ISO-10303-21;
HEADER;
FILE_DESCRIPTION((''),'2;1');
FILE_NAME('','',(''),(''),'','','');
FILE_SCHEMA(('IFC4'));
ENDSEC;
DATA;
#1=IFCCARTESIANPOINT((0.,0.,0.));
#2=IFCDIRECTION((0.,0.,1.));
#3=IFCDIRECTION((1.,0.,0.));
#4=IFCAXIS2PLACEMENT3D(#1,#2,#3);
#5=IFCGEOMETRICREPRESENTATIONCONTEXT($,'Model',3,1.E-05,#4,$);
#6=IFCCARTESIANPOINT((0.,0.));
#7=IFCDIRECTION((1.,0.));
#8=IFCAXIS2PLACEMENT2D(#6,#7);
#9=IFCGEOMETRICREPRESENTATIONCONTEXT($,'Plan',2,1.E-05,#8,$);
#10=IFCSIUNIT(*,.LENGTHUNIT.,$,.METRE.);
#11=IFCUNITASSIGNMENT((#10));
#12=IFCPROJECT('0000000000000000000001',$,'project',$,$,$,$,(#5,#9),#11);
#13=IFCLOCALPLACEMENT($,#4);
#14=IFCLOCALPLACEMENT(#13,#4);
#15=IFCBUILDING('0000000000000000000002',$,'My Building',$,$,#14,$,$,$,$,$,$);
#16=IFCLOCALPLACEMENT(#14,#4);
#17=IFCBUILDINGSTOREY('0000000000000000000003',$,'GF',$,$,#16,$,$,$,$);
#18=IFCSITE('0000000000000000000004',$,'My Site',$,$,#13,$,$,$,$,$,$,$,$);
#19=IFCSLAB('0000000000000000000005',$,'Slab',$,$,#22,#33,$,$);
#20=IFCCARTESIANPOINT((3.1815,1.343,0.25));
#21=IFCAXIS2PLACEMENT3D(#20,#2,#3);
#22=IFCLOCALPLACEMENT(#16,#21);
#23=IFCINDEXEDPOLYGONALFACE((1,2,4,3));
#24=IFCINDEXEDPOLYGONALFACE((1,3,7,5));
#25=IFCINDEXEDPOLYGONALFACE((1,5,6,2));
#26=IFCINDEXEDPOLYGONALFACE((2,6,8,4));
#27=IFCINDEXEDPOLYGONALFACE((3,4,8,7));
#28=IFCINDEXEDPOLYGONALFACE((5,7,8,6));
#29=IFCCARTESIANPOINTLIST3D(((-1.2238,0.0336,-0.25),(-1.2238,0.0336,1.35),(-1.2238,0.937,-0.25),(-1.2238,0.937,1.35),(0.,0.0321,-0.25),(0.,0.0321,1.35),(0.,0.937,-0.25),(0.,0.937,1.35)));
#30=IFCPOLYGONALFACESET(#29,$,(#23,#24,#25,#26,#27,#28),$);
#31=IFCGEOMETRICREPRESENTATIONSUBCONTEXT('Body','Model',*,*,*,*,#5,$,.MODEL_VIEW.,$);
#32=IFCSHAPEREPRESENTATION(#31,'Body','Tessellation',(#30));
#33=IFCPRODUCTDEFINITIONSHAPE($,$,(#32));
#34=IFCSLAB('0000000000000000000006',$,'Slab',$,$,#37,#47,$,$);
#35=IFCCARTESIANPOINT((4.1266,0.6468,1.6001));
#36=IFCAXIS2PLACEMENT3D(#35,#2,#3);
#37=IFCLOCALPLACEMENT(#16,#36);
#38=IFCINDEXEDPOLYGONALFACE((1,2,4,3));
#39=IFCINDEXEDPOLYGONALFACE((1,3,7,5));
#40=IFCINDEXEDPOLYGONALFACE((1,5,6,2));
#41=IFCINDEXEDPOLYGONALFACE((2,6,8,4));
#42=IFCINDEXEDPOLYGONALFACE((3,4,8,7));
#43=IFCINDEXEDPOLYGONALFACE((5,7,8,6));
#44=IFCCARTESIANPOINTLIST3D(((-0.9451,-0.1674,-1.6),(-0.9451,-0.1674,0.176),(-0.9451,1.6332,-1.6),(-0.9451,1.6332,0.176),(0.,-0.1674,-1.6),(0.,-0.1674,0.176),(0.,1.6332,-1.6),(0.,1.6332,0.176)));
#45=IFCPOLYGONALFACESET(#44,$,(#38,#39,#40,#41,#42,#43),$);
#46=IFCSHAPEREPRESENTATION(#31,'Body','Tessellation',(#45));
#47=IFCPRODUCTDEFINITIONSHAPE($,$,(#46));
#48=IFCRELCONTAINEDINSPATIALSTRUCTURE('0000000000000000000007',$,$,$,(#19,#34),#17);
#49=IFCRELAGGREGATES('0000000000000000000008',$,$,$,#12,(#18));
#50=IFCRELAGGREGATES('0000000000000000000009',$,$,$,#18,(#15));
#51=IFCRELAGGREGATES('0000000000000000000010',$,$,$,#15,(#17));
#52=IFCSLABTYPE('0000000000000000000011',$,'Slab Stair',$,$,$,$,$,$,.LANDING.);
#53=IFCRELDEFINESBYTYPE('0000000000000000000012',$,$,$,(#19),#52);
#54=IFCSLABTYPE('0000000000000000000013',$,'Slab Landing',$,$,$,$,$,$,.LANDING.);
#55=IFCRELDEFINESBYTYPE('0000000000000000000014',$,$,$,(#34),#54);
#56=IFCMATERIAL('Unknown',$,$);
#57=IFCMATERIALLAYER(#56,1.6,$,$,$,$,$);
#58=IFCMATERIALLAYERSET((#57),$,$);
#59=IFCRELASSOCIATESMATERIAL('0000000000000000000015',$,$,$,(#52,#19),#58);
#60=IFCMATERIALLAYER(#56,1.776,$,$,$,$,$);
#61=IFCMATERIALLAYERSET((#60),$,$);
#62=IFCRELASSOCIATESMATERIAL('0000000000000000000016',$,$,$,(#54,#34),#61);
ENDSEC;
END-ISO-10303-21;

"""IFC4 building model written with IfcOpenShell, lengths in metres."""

from ifc_helpers import new_model, si_unit, frame, origin_with_axes, origin_2d_with_axis, place, context, subcontext, project, spatial, indexed_curve, outline, extrude, material, layer, layer_set, layer_usage, type_object, element, save


model = new_model("IFC4")

# Units and contexts
model_context = context("Model", 3, precision=1e-05, world=origin_with_axes())
plan_context = context("Plan", 2, precision=1e-05, world=origin_2d_with_axis())
body_context_1 = subcontext(model_context, "Body", "Model", "MODEL_VIEW")
ifc_project = project(units=[si_unit("LENGTHUNIT", "METRE")], contexts=[model_context, plan_context])

# Site, building, storey
site_placement = place(None, origin_with_axes())
site = spatial("IfcSite", under=ifc_project, at=site_placement, Name="My Site")
building_placement = place(site_placement, origin_with_axes())
building = spatial("IfcBuilding", under=site, at=building_placement, Name="My Building")
storey_placement = place(building_placement, origin_with_axes())
storey = spatial("IfcBuildingStorey", under=building, at=storey_placement, Name="GF")

# Slabs
ifc_material_1 = material(Name="Unknown")
ifc_layer_1 = layer(ifc_material_1, 1.6)
ifc_layer_set_1 = layer_set([ifc_layer_1])
ifc_layer_usage_1 = layer_usage(ifc_layer_set_1, "AXIS3", "POSITIVE", -0.25)
slab_type_1 = type_object("IfcSlabType", Name="Slab Stair", PredefinedType="LANDING", material=ifc_layer_set_1)
slab_1_placement = place(storey_placement, frame((3.1815, 1.343, 0.25), z_axis=(0.0, 0.0, 1.0), x_axis=(1.0, 0.0, 0.0)))
element("IfcSlab", 1, at=slab_1_placement, inside=storey, type_object=slab_type_1, material=ifc_layer_usage_1, Name="Slab", context=body_context_1, shape_type="SweptSolid", body=[
    extrude(outline(indexed_curve([(0.0, 0.0321), (-1.2238, 0.0336), (-1.2238, 0.937), (0.0, 0.937), (0.0, 0.0321)])), frame((0.0, 0.0, -0.25), z_axis=(0.0, 0.0, 1.0), x_axis=(1.0, 0.0, 0.0)), (0.0, 0.0, 1.0), 1.6),
])
ifc_layer_2 = layer(ifc_material_1, 1.776)
ifc_layer_set_2 = layer_set([ifc_layer_2])
ifc_layer_usage_2 = layer_usage(ifc_layer_set_2, "AXIS3", "POSITIVE", -1.6)
slab_type_2 = type_object("IfcSlabType", Name="Slab Landing", PredefinedType="LANDING", material=ifc_layer_set_2)
slab_2_placement = place(storey_placement, frame((4.1266, 0.6468, 1.6001), z_axis=(0.0, 0.0, 1.0), x_axis=(1.0, 0.0, 0.0)))
element("IfcSlab", 2, at=slab_2_placement, inside=storey, type_object=slab_type_2, material=ifc_layer_usage_2, Name="Slab", context=body_context_1, shape_type="SweptSolid", body=[
    extrude(outline(indexed_curve([(-0.9451, -0.1674), (-0.9451, 1.6332), (0.0, 1.6332), (0.0, -0.1674), (-0.9451, -0.1674)])), frame((0.0, 0.0, -1.6), z_axis=(0.0, 0.0, 1.0), x_axis=(1.0, 0.0, 0.0)), (0.0, 0.0, 1.0), 1.776),
])

save(model, "model.ifc")
